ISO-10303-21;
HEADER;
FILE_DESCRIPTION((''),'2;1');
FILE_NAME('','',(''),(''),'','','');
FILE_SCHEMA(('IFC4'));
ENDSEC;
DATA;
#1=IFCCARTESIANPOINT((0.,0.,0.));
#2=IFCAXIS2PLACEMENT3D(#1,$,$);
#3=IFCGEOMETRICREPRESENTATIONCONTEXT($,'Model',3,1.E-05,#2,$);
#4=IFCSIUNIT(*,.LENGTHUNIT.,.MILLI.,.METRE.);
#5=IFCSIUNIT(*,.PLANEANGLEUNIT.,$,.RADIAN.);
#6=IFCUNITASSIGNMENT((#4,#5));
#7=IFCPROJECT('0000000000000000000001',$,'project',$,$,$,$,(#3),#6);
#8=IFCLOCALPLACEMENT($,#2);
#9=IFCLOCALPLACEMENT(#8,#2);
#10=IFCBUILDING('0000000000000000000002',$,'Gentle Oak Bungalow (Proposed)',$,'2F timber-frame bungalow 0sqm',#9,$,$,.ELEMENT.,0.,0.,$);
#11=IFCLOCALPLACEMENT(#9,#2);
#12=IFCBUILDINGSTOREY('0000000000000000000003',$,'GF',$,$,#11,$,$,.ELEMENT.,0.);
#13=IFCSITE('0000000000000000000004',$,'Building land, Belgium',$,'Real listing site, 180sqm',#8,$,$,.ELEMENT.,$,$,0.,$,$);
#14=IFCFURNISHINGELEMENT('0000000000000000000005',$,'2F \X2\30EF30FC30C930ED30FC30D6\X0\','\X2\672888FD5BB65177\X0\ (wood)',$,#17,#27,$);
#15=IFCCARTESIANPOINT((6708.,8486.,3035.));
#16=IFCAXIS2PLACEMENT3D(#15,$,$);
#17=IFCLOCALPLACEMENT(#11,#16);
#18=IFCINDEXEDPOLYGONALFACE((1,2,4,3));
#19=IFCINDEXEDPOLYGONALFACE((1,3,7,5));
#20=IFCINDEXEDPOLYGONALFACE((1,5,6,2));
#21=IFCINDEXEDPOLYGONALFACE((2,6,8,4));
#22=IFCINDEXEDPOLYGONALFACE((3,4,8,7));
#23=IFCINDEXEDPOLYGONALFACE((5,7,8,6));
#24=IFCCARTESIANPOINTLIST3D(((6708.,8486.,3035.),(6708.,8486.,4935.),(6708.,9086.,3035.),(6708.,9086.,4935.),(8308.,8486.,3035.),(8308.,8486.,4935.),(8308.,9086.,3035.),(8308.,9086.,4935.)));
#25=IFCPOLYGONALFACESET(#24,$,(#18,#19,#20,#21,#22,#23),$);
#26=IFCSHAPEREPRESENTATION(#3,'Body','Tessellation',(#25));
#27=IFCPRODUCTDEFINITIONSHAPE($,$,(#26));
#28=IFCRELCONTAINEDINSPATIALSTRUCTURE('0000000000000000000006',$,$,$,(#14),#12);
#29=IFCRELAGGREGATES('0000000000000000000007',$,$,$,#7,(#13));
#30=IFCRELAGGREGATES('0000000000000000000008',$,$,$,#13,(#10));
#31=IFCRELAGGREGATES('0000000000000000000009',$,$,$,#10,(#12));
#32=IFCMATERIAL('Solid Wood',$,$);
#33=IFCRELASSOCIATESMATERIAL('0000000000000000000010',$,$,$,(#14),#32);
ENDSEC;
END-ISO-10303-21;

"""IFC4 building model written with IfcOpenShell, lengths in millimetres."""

from ifc_helpers import new_model, si_unit, frame, frame_2d, origin, place, context, project, spatial, rectangle, extrude, material, element, save


model = new_model("IFC4")

# Units and contexts
model_context = context("Model", 3, precision=1e-05, world=origin())
ifc_project = project(units=[si_unit("LENGTHUNIT", "METRE", prefix="MILLI"), si_unit("PLANEANGLEUNIT", "RADIAN")], contexts=[model_context])

# Site, building, storey
site_placement = place(None, origin())
site = spatial("IfcSite", under=ifc_project, at=site_placement, Name="Building land, Belgium", ObjectType="Real listing site, 180sqm", CompositionType="ELEMENT", RefElevation=0.0)
building_placement = place(site_placement, origin())
building = spatial("IfcBuilding", under=site, at=building_placement, Name="Gentle Oak Bungalow (Proposed)", ObjectType="2F timber-frame bungalow 0sqm", CompositionType="ELEMENT", ElevationOfRefHeight=0.0, ElevationOfTerrain=0.0)
storey_placement = place(building_placement, origin())
storey = spatial("IfcBuildingStorey", under=building, at=storey_placement, Name="GF", CompositionType="ELEMENT", Elevation=0.0)

# Shared definitions
ifc_material_1 = material(Name="Solid Wood")

# Furnishing element
furnishing_1_placement = place(storey_placement, frame((6708.0, 8486.0, 3035.0)))
element("IfcFurnishingElement", 1, at=furnishing_1_placement, inside=storey, material=ifc_material_1, Name="2F ワードローブ", Description="木製家具 (wood)", context=model_context, shape_type="SweptSolid", body=[
    extrude(rectangle(XDim=1600.0, YDim=600.0, at=frame_2d((800.0, 300.0))), frame((6708.0, 8486.0, 3035.0)), (0.0, 0.0, 1.0), 1900.0),
])

save(model, "model.ifc")
